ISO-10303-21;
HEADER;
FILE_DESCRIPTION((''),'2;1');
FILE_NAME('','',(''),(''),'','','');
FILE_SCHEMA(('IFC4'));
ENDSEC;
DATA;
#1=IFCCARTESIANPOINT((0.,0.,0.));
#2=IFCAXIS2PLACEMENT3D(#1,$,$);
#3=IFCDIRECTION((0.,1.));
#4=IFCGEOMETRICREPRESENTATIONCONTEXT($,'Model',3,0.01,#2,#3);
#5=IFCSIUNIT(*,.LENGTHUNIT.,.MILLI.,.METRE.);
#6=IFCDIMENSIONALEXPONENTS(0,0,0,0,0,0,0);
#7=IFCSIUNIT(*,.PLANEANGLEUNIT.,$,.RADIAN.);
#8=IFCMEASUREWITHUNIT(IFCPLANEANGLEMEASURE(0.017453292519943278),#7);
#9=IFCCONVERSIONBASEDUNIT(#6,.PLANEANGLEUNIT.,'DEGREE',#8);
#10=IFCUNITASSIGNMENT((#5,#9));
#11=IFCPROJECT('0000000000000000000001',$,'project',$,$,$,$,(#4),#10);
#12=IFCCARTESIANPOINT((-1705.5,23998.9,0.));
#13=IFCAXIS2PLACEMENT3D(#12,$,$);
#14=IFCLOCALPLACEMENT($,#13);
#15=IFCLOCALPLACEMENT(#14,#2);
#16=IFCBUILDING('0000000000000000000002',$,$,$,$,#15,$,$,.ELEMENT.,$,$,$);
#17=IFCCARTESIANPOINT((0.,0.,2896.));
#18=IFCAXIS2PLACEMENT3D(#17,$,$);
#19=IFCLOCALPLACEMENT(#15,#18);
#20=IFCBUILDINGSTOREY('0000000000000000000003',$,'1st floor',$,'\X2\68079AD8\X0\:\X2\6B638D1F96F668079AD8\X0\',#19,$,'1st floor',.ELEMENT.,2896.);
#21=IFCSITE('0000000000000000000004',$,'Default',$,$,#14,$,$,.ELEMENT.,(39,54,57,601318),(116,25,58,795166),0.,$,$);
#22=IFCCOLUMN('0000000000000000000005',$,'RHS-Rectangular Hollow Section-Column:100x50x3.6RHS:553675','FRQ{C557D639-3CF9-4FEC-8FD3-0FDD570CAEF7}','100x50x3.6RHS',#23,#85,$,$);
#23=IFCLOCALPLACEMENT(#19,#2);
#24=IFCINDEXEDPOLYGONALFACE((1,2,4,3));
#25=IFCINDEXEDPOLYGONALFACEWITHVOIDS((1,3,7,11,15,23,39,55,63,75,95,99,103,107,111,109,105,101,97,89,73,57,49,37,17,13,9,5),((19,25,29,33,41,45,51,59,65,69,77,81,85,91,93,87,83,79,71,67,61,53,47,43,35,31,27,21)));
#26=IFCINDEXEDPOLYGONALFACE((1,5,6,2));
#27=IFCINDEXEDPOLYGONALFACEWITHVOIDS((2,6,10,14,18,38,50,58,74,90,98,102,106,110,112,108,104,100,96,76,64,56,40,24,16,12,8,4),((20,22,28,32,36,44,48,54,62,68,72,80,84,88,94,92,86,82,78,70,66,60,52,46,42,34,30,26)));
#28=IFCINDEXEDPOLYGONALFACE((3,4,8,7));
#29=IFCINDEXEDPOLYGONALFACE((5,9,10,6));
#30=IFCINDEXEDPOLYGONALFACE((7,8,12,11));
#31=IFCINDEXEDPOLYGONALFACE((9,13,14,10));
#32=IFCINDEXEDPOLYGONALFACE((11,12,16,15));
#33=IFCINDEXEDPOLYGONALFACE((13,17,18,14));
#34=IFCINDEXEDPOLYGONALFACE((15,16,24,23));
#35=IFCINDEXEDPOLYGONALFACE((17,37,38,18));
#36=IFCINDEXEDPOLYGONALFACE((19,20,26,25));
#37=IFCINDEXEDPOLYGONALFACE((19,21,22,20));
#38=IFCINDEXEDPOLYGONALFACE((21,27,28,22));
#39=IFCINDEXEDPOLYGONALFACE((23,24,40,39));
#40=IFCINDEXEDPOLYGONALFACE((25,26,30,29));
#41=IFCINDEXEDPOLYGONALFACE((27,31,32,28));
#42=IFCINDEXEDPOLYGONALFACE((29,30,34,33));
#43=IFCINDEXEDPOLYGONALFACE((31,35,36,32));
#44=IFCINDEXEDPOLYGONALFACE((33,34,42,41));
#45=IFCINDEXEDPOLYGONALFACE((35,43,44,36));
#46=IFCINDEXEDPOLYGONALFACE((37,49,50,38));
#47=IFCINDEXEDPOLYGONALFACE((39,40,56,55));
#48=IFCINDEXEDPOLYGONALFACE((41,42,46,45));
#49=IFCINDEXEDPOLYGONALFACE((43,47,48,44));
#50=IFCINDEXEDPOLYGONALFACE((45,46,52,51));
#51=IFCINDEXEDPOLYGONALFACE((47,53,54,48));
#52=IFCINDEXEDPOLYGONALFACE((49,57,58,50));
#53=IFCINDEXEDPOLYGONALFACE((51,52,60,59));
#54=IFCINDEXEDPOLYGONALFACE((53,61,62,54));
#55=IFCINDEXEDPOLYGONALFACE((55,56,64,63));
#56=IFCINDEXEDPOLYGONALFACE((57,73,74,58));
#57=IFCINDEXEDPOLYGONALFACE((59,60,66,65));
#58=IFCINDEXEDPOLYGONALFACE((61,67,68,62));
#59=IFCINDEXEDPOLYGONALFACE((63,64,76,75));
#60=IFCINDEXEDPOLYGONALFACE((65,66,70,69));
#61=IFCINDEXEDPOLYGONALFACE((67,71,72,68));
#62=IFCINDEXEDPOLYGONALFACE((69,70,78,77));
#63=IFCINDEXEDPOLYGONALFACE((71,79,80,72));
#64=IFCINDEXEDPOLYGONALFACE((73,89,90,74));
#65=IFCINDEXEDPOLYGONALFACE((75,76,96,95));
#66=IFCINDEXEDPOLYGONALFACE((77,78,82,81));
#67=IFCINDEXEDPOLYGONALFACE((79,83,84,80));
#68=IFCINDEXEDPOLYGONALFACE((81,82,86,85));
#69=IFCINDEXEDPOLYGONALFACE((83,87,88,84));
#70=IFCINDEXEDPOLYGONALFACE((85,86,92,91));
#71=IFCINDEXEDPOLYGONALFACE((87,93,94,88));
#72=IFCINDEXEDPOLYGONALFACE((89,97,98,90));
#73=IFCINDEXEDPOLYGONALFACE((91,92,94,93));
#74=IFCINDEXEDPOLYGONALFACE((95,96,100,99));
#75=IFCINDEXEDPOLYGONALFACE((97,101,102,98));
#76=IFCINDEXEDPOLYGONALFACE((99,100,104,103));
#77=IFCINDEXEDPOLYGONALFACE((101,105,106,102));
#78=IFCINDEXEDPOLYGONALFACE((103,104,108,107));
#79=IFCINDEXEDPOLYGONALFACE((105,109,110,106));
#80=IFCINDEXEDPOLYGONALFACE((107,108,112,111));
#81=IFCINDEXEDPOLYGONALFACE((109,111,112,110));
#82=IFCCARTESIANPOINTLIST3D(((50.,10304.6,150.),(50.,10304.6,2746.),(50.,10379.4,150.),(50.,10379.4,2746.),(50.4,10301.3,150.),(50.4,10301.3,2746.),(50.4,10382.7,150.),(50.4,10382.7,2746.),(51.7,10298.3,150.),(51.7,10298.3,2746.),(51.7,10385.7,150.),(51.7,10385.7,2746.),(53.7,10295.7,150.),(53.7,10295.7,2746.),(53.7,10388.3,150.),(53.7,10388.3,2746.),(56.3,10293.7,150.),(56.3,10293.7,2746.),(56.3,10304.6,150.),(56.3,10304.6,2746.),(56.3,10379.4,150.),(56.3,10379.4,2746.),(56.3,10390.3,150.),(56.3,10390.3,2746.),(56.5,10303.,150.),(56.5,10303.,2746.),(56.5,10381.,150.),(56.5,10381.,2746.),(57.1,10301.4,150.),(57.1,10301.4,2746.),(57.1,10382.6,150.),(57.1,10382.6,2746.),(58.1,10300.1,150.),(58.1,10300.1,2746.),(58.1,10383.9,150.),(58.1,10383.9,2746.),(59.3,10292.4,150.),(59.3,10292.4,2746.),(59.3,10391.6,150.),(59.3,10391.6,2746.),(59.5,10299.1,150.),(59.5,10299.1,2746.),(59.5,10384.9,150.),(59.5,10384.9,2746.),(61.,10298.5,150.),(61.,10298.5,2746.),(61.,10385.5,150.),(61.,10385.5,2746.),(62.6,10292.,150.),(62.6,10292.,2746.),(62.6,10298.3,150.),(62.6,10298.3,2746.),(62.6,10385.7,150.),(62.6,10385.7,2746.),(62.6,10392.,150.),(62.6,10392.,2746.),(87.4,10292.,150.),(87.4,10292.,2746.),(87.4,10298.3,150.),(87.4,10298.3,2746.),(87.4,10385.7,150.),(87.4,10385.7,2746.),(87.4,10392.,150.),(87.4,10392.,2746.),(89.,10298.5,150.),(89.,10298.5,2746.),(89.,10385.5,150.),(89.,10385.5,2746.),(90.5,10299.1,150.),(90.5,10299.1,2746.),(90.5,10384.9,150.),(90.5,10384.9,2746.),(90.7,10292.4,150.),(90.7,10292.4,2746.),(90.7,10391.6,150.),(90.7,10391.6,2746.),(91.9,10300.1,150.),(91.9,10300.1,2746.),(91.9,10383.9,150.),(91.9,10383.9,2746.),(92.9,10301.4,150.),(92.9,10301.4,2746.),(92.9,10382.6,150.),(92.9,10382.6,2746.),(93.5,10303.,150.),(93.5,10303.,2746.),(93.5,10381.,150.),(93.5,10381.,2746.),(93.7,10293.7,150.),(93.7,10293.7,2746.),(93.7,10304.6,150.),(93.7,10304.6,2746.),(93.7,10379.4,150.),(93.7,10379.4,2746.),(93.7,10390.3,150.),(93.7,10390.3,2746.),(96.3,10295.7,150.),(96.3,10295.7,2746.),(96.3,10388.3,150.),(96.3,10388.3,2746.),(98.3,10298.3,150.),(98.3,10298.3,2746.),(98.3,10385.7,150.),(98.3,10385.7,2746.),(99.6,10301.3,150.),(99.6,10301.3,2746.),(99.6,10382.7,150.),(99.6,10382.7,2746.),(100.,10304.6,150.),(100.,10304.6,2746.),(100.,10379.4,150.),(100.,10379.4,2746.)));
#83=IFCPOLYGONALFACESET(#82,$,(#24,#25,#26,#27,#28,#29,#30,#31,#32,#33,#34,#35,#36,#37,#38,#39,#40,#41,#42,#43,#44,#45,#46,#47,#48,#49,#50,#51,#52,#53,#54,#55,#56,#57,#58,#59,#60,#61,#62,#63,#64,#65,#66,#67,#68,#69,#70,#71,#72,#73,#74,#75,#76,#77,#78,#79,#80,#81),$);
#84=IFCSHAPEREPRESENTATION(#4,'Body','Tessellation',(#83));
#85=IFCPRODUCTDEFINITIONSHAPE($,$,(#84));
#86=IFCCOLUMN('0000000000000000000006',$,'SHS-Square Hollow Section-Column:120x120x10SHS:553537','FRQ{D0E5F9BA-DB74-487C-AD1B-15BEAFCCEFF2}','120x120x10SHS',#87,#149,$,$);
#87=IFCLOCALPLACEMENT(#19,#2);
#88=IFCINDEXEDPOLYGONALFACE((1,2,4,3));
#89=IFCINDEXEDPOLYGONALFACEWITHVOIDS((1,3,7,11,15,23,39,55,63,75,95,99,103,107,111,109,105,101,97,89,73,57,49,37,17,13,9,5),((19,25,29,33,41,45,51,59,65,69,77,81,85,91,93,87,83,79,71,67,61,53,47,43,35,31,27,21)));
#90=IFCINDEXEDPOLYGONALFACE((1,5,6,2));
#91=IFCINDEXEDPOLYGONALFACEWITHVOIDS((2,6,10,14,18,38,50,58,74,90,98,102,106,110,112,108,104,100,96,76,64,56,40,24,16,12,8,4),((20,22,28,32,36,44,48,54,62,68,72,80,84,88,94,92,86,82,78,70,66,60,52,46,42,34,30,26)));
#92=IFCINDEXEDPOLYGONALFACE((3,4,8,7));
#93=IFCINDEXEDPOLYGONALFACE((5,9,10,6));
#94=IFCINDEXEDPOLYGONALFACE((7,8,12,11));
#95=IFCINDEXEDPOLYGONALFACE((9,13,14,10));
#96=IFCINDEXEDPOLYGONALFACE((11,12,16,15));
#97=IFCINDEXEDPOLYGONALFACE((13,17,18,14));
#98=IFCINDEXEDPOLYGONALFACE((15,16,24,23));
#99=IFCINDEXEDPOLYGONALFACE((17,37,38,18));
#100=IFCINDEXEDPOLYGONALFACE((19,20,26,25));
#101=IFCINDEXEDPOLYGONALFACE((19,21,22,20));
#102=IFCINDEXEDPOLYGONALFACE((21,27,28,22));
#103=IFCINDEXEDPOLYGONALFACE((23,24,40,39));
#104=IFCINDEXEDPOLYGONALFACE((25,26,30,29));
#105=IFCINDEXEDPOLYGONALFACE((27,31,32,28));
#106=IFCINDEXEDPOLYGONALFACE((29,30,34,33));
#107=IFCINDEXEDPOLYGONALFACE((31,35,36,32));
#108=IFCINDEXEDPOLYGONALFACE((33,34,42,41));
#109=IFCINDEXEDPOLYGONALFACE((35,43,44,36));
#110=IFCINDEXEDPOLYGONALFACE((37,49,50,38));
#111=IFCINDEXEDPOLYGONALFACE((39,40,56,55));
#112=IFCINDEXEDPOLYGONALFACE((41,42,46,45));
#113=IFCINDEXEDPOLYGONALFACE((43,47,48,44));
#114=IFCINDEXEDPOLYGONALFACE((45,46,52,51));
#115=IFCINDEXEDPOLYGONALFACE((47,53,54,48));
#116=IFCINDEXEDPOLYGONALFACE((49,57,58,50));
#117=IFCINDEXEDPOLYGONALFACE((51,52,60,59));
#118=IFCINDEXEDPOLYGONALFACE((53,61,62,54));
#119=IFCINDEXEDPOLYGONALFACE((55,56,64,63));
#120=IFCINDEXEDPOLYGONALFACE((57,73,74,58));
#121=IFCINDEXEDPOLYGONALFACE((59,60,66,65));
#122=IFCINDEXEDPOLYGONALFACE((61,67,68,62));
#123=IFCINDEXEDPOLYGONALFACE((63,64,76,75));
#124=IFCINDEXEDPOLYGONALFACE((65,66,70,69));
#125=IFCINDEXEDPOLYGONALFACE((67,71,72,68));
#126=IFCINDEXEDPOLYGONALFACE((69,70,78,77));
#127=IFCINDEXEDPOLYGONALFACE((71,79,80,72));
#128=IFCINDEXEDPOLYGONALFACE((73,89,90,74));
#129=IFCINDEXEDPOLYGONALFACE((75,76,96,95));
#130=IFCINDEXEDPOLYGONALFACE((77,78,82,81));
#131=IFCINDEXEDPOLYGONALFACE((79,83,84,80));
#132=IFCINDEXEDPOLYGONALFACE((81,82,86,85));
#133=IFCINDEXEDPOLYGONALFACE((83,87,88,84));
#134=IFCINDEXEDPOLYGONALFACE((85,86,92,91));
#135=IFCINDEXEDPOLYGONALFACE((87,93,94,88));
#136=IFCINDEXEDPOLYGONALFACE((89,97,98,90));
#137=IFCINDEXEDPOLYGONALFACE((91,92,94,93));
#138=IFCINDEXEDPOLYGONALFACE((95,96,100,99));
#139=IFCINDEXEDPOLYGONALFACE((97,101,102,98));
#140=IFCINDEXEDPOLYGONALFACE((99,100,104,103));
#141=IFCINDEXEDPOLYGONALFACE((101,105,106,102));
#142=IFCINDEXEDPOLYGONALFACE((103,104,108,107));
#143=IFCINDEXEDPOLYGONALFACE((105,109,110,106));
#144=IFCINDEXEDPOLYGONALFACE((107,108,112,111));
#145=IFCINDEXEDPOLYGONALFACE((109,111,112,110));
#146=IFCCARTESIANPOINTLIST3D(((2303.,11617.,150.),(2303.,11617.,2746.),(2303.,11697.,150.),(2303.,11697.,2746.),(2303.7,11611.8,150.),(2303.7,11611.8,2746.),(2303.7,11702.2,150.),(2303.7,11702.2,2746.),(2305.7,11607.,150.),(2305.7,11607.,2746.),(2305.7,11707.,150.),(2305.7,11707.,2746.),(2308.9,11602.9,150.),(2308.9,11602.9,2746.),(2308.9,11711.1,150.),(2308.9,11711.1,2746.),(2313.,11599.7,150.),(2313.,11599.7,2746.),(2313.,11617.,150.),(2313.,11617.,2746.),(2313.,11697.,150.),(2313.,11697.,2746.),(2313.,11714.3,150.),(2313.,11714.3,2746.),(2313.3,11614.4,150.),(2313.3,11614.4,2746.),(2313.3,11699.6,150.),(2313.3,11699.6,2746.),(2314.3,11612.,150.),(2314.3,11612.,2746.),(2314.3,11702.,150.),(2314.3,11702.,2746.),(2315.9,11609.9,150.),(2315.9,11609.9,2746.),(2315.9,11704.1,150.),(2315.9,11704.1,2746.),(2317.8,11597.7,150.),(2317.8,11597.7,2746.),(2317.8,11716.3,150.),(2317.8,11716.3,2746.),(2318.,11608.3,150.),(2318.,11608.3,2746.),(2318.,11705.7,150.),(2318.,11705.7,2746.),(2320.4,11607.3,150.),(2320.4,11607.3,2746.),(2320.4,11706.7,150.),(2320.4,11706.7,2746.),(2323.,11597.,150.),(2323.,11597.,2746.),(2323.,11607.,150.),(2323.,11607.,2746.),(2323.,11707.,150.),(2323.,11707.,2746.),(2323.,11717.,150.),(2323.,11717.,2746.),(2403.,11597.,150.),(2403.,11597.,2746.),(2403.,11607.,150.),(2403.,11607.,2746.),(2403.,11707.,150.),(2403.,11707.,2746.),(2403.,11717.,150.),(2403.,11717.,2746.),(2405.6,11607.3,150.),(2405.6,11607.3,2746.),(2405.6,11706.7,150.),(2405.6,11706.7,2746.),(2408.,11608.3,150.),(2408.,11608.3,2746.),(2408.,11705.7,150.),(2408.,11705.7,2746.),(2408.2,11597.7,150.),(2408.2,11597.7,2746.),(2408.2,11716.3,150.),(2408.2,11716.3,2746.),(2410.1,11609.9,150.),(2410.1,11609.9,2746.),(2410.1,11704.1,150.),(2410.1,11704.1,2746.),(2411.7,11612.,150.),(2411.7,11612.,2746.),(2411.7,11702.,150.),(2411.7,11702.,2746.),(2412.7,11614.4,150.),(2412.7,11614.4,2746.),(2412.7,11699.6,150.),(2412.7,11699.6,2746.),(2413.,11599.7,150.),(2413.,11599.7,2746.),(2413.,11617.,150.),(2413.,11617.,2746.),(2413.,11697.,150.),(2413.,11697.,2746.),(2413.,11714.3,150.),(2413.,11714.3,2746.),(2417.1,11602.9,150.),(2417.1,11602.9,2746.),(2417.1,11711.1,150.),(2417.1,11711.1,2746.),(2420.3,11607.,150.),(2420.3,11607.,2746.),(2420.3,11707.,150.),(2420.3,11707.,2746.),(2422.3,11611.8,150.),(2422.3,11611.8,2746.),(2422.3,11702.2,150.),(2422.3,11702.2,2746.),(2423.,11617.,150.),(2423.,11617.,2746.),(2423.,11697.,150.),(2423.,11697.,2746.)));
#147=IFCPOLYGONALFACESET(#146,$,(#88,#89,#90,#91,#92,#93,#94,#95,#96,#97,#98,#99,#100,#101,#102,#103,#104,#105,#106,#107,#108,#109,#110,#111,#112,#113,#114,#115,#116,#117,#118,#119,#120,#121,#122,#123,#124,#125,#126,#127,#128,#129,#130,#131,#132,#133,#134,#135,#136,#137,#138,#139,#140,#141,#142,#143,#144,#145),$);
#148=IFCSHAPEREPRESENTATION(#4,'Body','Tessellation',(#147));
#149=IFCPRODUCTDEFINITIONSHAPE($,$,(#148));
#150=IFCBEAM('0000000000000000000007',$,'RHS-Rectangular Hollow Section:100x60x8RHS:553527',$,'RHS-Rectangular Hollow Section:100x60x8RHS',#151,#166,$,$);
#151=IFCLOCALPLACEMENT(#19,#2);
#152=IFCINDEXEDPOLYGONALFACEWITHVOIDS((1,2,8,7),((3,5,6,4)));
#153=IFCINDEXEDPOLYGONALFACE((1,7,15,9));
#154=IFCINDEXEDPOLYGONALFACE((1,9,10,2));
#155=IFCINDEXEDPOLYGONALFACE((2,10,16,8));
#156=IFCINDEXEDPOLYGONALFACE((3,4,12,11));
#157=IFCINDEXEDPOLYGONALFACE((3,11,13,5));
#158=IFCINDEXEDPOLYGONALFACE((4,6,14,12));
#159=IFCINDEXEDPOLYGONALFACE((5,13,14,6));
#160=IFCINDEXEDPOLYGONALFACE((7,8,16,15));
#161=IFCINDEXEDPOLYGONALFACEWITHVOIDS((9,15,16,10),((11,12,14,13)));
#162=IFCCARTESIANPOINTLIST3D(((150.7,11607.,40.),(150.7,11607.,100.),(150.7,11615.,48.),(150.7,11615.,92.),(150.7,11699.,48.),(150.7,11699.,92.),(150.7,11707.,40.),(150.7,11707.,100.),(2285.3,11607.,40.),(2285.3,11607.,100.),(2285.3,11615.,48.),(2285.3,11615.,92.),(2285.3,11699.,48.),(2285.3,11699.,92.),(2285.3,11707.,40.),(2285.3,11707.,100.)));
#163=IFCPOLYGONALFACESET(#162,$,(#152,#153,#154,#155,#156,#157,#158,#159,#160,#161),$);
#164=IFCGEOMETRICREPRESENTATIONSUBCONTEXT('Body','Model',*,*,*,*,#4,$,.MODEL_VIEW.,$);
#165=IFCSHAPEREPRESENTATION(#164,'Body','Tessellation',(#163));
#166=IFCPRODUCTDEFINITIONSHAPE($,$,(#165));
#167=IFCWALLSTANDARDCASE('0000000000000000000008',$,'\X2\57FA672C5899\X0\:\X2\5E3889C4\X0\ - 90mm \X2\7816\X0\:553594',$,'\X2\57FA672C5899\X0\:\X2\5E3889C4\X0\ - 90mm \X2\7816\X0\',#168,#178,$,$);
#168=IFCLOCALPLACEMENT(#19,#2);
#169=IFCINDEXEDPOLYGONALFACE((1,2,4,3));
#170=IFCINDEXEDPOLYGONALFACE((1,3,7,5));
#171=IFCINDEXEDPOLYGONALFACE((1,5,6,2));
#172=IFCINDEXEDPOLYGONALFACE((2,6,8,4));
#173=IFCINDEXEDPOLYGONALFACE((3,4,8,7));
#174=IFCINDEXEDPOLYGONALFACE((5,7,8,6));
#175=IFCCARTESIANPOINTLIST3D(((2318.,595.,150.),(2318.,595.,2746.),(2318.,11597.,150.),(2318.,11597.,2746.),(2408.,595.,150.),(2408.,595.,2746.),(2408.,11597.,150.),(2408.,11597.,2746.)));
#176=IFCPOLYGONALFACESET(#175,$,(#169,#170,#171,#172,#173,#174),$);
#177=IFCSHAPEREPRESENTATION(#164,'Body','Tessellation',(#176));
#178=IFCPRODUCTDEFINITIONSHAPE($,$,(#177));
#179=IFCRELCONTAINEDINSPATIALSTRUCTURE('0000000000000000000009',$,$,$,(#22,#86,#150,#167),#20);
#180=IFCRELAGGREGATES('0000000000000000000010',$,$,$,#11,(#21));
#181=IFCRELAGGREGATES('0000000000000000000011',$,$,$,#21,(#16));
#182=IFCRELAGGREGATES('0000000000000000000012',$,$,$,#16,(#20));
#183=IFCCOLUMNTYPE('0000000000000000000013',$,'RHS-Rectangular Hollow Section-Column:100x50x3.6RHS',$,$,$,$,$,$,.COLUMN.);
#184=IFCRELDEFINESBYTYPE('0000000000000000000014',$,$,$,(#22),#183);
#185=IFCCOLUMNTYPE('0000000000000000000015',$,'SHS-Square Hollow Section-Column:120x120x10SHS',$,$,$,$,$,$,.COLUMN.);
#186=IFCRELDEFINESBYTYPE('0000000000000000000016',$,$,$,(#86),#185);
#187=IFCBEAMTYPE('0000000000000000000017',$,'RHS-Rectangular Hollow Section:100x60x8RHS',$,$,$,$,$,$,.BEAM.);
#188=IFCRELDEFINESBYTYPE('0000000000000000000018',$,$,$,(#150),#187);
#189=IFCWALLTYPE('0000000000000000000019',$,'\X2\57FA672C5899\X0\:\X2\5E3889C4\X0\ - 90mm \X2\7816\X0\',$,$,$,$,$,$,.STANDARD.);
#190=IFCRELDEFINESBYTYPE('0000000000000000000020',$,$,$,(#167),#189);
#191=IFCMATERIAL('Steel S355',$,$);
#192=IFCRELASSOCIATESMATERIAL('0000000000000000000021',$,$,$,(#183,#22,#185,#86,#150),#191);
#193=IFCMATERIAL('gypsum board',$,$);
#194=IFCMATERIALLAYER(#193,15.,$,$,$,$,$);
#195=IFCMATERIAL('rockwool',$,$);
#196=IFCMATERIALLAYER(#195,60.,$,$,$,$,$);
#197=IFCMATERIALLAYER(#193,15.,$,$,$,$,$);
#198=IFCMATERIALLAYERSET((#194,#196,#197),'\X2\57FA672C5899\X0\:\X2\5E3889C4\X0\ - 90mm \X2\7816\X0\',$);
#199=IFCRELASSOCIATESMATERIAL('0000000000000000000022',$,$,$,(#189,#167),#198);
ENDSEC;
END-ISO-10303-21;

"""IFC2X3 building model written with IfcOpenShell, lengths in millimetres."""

from ifc_helpers import new_model, entity, si_unit, converted_unit, direction, frame, frame_2d, origin, origin_2d, place, context, subcontext, project, spatial, rectangle, hollow_rectangle, extrude, boolean, clip, halfspace, material, layer, layer_set, layer_usage, type_object, element, save


model = new_model("IFC2X3")

# Units and contexts
model_context = context("Model", 3, precision=0.01, world=origin(), true_north=direction((0.0, 1.0)))
body_context = subcontext(model_context, "Body", "Model", "MODEL_VIEW")
ifc_project = project(units=[si_unit("LENGTHUNIT", "METRE", prefix="MILLI"), converted_unit("PLANEANGLEUNIT", "DEGREE", entity("IfcPlaneAngleMeasure", 0.017453292519943278), si_unit("PLANEANGLEUNIT", "RADIAN"), dimensions=[0, 0, 0, 0, 0, 0, 0])], contexts=[model_context])

# Site, building, storey
site_placement = place(None, frame((-1705.5, 23998.9, 0.0)))
site = spatial("IfcSite", under=ifc_project, at=site_placement, Name="Default", CompositionType="ELEMENT", RefLatitude=(39, 54, 57, 601318), RefLongitude=(116, 25, 58, 795166), RefElevation=0.0)
building_placement = place(site_placement, origin())
building = spatial("IfcBuilding", under=site, at=building_placement, CompositionType="ELEMENT")
storey_placement = place(building_placement, frame((0.0, 0.0, 2896.0)))
storey = spatial("IfcBuildingStorey", under=building, at=storey_placement, Name="1st floor", ObjectType="标高:正负零标高", LongName="1st floor", CompositionType="ELEMENT", Elevation=2896.0)

# Shared definitions
ifc_material_1 = material(Name="Steel S355")

# Columns
column_type_1 = type_object("IfcColumnType", Name="RHS-Rectangular Hollow Section-Column:100x50x3.6RHS", PredefinedType="COLUMN", material=ifc_material_1)
column_1_placement = place(storey_placement, frame((75.0, 10342.0, 2746.0), z_axis=(0.0, 0.0, 1.0), x_axis=(-1.0, 0.0, 0.0)))
element("IfcColumn", 1, at=column_1_placement, inside=storey, type_object=column_type_1, material=ifc_material_1, Name="RHS-Rectangular Hollow Section-Column:100x50x3.6RHS:553675", Description="FRQ{C557D639-3CF9-4FEC-8FD3-0FDD570CAEF7}", ObjectType="100x50x3.6RHS", context=model_context, shape_type="Clipping", body=[
    clip(extrude(hollow_rectangle(XDim=50.0, YDim=100.0, WallThickness=6.3, InnerFilletRadius=6.3, OuterFilletRadius=12.6, at=origin_2d()), origin(), (0.0, 0.0, -1.0), 2651.9), halfspace(frame((75.0, 10342.0, -2596.0), z_axis=(0.0, 0.0, 1.0), x_axis=(-1.0, 0.0, 0.0)), True)),
])
column_type_2 = type_object("IfcColumnType", Name="SHS-Square Hollow Section-Column:120x120x10SHS", PredefinedType="COLUMN", material=ifc_material_1)
column_2_placement = place(storey_placement, frame((2363.0, 11657.0, 2830.9), z_axis=(0.0, 0.0, 1.0), x_axis=(0.0, -1.0, 0.0)))
element("IfcColumn", 2, at=column_2_placement, inside=storey, type_object=column_type_2, material=ifc_material_1, Name="SHS-Square Hollow Section-Column:120x120x10SHS:553537", Description="FRQ{D0E5F9BA-DB74-487C-AD1B-15BEAFCCEFF2}", ObjectType="120x120x10SHS", context=model_context, shape_type="Clipping", body=[
    clip(clip(extrude(hollow_rectangle(XDim=120.0, YDim=120.0, WallThickness=10.0, InnerFilletRadius=10.0, OuterFilletRadius=20.0, at=origin_2d()), origin(), (0.0, 0.0, -1.0), 2765.7), halfspace(frame((11657.0, -2363.0, -2680.9), z_axis=(0.0, 0.0, 1.0), x_axis=(0.0, 1.0, 0.0)), True)), halfspace(frame((11657.0, -2363.0, -84.9), z_axis=(0.0, 0.0, -1.0), x_axis=(0.0, -1.0, 0.0)), True)),
])

# Beam
beam_type_1 = type_object("IfcBeamType", Name="RHS-Rectangular Hollow Section:100x60x8RHS", PredefinedType="BEAM")
beam_1_placement = place(storey_placement, frame((150.7, 11707.0, 70.0)))
element("IfcBeam", 3, at=beam_1_placement, inside=storey, type_object=beam_type_1, material=ifc_material_1, Name="RHS-Rectangular Hollow Section:100x60x8RHS:553527", ObjectType="RHS-Rectangular Hollow Section:100x60x8RHS", context=body_context, shape_type="SweptSolid", body=[
    boolean("DIFFERENCE", extrude(rectangle(XDim=60.0, YDim=100.0, at=frame_2d((0.0, 0.0), x_axis=(1.0, 0.0))), frame((0.0, -50.0, 0.0), z_axis=(1.0, 0.0, 0.0), x_axis=(0.0, 0.0, -1.0)), (0.0, 0.0, 1.0), 2134.6), extrude(rectangle(XDim=44.0, YDim=84.0, at=frame_2d((0.0, 0.0), x_axis=(0.0, 1.0))), frame((2134.6, -50.0, 0.0), z_axis=(-1.0, 0.0, 0.0), x_axis=(0.0, 1.0, 0.0)), (0.0, 0.0, 1.0), 2134.6)),
])

# Wall
ifc_material_2 = material(Name="gypsum board")
ifc_layer_1 = layer(ifc_material_2, 15.0)
ifc_material_3 = material(Name="rockwool")
ifc_layer_2 = layer(ifc_material_3, 60.0)
ifc_layer_3 = layer(ifc_material_2, 15.0)
ifc_layer_set = layer_set([ifc_layer_1, ifc_layer_2, ifc_layer_3], Name="基本墙:常规 - 90mm 砖")
ifc_layer_usage_1 = layer_usage(ifc_layer_set, "AXIS2", "NEGATIVE", 45.0)
wall_type = type_object("IfcWallType", Name="基本墙:常规 - 90mm 砖", PredefinedType="STANDARD", material=ifc_layer_set)
wall_1_placement = place(storey_placement, frame((2363.0, 11597.0, 150.0), z_axis=(0.0, 0.0, 1.0), x_axis=(0.0, -1.0, 0.0)))
element("IfcWallStandardCase", 4, at=wall_1_placement, inside=storey, type_object=wall_type, material=ifc_layer_usage_1, Name="基本墙:常规 - 90mm 砖:553594", ObjectType="基本墙:常规 - 90mm 砖", context=body_context, shape_type="SweptSolid", body=[
    extrude(rectangle(XDim=11002.0, YDim=90.0, at=frame_2d((5501.0, 0.0), x_axis=(-1.0, 0.0))), origin(), (0.0, 0.0, 1.0), 2596.0),
])

save(model, "model.ifc")
